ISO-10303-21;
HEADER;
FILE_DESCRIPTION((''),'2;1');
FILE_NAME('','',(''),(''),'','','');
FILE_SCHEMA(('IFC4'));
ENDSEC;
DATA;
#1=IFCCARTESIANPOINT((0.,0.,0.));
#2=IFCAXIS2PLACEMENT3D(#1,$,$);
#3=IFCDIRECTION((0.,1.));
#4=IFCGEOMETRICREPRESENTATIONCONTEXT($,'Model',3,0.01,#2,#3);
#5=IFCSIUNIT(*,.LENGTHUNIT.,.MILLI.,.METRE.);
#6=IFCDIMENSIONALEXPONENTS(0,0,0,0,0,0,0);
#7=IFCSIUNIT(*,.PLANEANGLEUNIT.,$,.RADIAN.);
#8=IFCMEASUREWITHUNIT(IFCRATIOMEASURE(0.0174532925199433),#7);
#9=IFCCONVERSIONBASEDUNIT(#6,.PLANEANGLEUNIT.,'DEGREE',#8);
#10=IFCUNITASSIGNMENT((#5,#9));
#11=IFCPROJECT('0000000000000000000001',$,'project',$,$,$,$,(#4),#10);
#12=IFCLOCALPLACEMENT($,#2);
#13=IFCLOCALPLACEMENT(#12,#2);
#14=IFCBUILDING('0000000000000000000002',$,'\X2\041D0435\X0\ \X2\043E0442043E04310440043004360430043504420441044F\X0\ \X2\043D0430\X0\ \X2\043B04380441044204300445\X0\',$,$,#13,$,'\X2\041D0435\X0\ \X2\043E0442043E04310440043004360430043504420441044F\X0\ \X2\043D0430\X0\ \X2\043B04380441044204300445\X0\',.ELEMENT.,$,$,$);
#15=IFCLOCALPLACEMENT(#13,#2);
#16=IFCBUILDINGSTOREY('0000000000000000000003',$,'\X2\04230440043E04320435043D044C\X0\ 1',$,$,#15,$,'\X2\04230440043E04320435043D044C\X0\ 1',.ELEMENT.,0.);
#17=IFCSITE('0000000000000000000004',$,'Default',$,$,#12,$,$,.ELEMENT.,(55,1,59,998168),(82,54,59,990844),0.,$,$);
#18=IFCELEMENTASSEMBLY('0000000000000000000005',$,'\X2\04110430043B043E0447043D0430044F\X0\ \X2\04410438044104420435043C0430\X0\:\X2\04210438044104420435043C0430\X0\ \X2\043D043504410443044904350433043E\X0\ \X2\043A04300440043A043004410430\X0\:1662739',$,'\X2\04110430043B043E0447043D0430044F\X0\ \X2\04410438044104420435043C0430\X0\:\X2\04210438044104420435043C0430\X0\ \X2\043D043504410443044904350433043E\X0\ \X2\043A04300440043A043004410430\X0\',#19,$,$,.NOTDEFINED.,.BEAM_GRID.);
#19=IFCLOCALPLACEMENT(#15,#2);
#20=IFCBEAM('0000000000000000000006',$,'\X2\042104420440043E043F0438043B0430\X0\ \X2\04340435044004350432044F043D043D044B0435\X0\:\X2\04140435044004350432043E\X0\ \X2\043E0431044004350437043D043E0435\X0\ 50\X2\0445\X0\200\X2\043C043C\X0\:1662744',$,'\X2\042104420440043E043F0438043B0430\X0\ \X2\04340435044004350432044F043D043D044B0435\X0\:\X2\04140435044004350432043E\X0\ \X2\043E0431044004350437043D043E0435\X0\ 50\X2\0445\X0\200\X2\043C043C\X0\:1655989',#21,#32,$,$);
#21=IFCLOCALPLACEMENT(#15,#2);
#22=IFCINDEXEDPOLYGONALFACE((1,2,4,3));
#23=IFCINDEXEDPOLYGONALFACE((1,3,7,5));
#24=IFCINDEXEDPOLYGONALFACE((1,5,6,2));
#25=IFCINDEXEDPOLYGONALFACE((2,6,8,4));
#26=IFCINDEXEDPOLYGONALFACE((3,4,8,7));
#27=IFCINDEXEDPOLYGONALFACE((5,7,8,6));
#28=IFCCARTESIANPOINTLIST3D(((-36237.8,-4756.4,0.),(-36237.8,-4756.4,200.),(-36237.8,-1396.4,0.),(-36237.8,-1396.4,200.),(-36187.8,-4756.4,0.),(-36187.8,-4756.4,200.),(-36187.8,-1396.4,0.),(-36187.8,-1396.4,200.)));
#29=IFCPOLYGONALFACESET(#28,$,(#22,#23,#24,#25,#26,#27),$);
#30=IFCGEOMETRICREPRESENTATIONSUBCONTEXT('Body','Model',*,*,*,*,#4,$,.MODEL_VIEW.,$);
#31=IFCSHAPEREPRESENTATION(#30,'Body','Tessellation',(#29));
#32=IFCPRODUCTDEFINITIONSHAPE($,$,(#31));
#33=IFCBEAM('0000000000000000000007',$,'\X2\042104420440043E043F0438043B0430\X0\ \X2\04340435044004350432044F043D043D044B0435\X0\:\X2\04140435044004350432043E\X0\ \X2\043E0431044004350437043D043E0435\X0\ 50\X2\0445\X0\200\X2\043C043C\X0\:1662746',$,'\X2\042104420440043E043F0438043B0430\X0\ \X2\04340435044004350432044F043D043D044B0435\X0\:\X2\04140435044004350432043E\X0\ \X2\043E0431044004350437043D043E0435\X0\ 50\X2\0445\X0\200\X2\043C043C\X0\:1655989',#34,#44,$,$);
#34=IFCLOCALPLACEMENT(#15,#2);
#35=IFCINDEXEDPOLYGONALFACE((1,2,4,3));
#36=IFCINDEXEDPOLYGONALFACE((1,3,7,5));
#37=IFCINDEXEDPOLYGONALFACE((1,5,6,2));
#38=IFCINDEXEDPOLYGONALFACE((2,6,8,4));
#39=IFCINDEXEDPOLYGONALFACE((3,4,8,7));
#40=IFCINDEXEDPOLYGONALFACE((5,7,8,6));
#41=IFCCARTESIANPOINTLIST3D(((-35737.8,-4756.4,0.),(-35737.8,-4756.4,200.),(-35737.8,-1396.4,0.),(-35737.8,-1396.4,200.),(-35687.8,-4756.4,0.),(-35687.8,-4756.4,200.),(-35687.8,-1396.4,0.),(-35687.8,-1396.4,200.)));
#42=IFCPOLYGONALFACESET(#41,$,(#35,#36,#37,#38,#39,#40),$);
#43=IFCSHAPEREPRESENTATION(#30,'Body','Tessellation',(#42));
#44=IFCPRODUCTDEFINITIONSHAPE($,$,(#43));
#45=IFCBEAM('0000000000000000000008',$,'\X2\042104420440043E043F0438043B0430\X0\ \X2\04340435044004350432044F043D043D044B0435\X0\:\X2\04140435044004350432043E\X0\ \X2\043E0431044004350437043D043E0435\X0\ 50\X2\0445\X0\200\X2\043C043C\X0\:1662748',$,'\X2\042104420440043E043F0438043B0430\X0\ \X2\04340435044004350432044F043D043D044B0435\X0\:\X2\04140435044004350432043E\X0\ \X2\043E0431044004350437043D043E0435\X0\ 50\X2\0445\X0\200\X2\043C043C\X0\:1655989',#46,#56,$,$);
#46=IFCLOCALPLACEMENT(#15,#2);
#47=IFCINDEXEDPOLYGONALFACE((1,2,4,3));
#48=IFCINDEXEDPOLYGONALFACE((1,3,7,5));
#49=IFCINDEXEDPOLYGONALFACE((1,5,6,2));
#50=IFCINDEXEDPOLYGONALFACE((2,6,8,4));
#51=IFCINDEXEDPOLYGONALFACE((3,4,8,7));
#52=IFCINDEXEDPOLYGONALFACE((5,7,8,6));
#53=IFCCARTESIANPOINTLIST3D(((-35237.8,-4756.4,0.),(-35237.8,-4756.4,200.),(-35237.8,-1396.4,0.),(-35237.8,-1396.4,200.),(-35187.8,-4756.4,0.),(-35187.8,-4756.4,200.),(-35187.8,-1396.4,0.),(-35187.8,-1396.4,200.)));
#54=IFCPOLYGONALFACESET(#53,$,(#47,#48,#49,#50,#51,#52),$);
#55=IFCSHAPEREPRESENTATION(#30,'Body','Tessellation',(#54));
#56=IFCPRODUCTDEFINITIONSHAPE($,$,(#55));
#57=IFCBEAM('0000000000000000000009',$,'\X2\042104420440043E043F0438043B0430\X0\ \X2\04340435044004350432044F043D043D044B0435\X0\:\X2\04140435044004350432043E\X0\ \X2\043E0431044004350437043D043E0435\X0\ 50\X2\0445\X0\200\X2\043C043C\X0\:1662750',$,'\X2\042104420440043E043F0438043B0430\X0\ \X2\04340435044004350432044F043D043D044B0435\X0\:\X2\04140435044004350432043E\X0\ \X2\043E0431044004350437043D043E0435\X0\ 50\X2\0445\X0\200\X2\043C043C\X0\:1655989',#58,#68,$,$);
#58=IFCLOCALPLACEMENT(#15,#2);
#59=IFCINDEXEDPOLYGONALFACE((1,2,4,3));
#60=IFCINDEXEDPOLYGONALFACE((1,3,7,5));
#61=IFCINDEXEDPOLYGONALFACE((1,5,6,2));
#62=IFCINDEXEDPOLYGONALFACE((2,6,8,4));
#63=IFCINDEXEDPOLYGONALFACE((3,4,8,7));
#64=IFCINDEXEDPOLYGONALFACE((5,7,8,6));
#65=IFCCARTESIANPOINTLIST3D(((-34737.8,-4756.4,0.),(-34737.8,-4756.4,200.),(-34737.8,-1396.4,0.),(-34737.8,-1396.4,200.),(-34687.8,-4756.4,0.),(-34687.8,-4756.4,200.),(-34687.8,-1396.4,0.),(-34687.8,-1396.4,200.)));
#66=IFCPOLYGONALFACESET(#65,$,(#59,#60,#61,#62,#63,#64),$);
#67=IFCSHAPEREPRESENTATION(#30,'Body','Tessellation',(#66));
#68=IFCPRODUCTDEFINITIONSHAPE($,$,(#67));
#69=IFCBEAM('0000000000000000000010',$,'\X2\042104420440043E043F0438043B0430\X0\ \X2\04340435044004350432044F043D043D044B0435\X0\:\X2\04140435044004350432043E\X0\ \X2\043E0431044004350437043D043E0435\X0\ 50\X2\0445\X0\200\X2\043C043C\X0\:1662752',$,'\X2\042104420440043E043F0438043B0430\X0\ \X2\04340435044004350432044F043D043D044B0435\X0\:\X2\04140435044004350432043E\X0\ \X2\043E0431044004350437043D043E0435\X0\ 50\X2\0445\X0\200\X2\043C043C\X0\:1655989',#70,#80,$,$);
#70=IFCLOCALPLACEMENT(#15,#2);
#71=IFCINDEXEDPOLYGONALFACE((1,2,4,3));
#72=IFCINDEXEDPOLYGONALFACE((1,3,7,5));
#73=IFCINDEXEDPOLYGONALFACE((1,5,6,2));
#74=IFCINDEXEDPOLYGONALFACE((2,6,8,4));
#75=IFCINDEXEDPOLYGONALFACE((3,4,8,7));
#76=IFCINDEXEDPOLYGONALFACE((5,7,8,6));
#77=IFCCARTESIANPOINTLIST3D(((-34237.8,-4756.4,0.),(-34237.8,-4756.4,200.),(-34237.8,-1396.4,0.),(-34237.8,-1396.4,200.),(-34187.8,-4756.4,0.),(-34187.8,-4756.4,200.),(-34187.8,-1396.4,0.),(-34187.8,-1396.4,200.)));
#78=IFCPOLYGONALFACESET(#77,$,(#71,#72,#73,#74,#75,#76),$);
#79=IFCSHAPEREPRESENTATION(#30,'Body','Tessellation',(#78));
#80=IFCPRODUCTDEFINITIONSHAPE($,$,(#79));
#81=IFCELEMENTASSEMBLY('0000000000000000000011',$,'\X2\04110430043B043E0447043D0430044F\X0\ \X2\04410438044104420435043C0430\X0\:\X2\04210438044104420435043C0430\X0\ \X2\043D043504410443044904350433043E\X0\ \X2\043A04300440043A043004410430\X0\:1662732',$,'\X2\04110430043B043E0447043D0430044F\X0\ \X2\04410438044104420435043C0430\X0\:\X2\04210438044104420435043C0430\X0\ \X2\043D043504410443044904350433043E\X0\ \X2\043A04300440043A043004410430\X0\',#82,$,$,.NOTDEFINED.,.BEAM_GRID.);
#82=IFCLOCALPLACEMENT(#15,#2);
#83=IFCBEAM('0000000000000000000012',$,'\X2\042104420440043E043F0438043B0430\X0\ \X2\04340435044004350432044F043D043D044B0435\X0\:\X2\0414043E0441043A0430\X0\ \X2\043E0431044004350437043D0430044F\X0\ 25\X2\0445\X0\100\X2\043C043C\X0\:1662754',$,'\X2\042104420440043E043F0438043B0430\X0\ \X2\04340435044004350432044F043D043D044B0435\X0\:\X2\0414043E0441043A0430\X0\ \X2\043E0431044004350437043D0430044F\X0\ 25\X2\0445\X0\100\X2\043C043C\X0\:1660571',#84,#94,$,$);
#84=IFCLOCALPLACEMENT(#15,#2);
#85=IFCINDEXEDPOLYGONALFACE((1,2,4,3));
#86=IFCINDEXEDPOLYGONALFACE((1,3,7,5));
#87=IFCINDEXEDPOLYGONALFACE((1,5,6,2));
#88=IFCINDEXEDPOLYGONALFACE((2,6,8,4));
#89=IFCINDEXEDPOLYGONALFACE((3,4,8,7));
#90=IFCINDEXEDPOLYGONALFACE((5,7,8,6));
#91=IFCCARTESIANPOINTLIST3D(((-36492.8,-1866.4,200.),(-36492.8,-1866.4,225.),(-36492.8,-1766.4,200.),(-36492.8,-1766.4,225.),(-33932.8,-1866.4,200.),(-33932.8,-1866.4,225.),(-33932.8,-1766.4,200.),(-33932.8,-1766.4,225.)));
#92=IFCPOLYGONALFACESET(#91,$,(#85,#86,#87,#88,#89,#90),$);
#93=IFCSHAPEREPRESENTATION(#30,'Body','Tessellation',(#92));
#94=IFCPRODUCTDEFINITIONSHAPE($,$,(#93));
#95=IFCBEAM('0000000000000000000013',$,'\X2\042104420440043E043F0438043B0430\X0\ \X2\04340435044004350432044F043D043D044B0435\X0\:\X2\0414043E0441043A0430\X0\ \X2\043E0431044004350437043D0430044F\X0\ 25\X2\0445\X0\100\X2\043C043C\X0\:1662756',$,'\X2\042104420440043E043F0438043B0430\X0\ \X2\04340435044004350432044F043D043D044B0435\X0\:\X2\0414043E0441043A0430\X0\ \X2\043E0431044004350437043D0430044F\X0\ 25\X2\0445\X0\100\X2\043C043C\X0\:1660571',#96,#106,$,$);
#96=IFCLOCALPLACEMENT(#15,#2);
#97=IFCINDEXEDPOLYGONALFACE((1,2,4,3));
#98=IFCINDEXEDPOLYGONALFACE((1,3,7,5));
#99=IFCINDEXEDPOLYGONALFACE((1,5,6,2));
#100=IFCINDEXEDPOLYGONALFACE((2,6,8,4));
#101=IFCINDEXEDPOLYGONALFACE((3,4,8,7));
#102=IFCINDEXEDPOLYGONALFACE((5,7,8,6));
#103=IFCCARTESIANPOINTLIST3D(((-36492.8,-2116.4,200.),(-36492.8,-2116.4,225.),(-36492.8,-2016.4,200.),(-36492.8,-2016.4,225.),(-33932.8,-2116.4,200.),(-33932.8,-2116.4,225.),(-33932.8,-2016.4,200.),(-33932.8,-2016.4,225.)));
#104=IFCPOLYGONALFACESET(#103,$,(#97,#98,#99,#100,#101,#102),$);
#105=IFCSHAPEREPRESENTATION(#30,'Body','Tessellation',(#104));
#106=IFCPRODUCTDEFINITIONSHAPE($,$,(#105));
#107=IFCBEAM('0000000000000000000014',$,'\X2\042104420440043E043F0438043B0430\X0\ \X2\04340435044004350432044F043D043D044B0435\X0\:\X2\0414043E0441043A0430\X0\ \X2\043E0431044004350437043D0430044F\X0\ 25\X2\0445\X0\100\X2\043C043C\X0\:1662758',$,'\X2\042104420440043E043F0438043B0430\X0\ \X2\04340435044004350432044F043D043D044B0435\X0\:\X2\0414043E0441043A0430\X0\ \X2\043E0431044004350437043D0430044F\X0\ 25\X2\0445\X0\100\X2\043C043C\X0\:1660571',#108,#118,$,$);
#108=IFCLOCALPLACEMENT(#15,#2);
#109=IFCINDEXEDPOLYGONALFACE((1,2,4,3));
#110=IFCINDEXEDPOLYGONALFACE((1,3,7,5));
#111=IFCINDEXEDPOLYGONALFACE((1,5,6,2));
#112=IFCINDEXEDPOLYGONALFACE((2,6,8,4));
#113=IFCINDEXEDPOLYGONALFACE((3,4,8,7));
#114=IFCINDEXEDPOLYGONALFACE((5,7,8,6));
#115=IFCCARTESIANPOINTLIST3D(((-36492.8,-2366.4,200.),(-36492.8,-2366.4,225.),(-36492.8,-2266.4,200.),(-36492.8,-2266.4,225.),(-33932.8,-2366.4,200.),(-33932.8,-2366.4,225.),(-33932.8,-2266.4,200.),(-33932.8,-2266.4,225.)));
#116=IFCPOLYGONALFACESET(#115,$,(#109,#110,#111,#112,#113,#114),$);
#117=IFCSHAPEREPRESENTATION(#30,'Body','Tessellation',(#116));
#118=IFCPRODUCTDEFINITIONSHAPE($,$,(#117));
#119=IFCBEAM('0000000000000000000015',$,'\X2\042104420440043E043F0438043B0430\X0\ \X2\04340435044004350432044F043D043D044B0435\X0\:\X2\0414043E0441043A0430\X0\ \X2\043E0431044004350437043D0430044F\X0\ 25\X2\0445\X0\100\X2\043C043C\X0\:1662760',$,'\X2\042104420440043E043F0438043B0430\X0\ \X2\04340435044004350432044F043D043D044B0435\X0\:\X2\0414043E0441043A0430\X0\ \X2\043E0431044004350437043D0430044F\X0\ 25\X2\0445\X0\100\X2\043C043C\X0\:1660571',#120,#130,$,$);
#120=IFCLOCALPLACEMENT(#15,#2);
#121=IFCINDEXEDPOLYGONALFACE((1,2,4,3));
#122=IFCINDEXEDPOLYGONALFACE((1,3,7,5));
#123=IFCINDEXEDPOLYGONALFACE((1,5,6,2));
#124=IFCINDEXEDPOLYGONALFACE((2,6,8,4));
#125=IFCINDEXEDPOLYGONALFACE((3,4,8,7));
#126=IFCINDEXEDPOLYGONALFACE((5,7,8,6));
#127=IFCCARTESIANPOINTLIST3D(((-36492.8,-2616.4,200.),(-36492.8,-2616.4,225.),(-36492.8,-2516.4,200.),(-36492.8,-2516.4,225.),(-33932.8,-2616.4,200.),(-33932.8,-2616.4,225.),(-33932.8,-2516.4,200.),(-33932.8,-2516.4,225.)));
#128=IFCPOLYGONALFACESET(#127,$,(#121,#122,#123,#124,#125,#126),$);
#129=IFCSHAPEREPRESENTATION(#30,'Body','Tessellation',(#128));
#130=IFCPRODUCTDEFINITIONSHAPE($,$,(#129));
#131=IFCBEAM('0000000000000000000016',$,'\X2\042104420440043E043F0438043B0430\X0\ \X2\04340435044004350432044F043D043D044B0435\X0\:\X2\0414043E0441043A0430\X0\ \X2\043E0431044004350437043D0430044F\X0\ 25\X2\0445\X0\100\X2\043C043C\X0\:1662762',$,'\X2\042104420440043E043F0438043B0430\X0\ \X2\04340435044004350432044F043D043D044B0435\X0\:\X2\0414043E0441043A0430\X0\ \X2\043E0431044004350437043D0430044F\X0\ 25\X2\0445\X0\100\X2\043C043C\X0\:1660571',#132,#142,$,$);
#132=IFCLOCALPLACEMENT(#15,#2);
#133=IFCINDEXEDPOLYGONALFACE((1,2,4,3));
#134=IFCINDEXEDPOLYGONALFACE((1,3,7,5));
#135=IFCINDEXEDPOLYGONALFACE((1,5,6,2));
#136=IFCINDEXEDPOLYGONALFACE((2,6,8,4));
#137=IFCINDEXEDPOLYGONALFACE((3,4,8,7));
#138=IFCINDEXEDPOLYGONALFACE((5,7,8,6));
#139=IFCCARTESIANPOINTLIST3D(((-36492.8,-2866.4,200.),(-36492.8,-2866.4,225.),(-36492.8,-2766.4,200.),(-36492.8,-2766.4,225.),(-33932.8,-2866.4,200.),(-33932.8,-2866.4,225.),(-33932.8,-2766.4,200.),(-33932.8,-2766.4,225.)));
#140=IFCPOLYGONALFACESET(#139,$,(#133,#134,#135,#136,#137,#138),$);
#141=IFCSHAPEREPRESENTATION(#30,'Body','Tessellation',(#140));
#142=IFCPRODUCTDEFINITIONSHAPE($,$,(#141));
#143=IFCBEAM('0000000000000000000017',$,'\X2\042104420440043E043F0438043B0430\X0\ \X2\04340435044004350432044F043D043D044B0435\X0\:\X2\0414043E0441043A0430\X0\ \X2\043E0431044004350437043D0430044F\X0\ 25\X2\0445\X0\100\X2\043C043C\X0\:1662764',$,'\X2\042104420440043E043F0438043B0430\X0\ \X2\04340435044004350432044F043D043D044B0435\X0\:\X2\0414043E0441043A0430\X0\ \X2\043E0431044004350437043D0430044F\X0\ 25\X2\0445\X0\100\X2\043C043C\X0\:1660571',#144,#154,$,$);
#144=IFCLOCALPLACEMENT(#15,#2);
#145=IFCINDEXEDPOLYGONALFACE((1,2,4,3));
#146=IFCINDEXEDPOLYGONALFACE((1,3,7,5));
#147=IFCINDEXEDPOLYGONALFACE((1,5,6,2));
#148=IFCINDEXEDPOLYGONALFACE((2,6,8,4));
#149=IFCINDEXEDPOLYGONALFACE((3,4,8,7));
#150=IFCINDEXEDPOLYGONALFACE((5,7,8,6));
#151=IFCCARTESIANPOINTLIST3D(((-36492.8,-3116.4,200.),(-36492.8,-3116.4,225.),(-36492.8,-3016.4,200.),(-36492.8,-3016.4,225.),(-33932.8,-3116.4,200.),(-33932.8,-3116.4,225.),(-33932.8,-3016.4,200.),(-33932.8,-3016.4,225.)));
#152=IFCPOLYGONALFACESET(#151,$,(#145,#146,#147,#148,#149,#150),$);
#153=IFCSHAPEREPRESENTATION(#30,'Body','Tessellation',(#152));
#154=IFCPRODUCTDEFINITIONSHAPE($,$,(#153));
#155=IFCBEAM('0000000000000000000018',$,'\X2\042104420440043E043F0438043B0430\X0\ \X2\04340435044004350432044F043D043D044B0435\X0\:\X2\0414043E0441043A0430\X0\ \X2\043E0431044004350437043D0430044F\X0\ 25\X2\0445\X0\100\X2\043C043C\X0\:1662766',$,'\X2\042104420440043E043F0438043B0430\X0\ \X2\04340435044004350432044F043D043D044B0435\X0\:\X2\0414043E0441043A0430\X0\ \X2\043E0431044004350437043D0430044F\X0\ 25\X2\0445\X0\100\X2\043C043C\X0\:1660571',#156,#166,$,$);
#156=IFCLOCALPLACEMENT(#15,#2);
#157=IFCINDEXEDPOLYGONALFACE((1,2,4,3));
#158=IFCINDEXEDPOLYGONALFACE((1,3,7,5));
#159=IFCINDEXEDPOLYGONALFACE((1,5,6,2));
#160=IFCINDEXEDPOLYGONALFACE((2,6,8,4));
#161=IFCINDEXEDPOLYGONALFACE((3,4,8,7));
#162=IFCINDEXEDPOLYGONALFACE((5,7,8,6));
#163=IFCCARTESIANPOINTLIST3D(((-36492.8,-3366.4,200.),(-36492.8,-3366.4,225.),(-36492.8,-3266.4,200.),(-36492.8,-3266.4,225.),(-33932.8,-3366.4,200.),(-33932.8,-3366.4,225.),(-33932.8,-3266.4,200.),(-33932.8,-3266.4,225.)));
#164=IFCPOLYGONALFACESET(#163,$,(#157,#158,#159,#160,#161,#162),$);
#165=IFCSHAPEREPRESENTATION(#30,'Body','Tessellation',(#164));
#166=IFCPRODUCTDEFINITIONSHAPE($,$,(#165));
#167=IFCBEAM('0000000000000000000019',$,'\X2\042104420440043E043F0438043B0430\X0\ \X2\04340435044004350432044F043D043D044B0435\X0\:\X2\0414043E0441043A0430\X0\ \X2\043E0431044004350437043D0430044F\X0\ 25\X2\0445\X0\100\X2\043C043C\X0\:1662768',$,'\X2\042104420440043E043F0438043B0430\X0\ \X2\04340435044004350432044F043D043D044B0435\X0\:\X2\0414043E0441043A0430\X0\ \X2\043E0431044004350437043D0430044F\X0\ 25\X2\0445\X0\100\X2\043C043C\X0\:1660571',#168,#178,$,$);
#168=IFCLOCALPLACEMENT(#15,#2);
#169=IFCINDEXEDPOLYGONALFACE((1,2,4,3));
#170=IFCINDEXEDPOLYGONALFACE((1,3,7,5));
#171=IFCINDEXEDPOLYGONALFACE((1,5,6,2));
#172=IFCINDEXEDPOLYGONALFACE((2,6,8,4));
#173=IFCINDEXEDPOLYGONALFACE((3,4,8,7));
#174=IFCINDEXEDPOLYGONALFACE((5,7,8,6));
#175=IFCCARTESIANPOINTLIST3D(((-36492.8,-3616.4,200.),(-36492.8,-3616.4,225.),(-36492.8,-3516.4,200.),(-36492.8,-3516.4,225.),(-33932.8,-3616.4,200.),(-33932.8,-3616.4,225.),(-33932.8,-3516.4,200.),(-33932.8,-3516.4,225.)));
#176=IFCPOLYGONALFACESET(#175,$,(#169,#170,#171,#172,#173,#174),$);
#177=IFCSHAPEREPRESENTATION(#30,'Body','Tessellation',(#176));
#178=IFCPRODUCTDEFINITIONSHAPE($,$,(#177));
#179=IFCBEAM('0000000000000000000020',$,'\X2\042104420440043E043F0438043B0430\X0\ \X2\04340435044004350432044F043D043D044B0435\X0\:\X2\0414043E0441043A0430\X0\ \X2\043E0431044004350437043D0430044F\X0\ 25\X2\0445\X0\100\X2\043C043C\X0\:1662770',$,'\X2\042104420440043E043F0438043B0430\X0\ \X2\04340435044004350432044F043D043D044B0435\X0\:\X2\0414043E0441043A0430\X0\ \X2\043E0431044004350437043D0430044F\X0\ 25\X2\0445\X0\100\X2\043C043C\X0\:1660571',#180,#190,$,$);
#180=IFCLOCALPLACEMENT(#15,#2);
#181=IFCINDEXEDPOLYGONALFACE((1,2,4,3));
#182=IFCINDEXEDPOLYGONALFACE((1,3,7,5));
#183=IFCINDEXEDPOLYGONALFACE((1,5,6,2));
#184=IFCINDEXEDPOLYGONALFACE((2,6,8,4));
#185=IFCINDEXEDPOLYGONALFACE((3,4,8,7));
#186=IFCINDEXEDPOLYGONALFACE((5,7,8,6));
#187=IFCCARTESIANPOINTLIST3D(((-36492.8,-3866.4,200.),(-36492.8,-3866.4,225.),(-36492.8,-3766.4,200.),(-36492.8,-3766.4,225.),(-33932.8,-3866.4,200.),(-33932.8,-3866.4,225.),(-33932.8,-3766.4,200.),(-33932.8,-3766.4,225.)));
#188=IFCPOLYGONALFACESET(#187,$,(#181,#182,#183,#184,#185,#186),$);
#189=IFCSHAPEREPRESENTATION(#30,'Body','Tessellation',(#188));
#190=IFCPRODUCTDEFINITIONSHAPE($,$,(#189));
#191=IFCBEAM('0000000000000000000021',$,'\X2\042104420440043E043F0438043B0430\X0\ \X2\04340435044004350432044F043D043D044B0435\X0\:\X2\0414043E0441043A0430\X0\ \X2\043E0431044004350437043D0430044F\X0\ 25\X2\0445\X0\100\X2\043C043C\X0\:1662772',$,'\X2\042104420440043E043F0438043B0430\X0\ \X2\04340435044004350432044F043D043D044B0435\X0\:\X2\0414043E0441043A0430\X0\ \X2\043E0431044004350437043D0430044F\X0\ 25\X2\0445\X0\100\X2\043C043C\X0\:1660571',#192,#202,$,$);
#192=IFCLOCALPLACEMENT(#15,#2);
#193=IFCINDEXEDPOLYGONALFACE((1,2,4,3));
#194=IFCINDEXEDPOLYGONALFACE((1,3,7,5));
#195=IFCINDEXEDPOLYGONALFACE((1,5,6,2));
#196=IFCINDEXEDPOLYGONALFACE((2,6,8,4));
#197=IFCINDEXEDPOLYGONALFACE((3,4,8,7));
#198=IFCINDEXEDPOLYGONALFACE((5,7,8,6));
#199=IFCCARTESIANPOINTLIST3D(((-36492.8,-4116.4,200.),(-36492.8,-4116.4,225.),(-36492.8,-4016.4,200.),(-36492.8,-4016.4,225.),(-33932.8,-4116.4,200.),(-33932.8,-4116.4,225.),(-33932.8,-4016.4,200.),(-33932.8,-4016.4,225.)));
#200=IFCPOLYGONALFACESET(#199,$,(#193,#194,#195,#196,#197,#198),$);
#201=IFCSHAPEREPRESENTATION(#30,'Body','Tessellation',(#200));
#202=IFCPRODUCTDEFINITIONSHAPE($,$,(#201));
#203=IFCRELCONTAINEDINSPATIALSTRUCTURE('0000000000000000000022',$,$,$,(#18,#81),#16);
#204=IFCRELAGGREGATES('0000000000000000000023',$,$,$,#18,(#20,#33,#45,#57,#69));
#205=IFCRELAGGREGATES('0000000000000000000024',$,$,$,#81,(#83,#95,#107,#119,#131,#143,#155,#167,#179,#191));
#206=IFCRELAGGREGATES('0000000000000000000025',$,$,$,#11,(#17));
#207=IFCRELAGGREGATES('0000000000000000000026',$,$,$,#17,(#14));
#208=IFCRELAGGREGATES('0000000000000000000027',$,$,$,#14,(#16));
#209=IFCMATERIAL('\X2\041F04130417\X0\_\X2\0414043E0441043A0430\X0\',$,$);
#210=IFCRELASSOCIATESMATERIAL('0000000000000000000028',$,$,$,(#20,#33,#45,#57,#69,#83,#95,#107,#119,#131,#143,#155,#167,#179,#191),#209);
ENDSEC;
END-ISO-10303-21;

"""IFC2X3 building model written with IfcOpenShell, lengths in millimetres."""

from ifc_helpers import new_model, entity, si_unit, converted_unit, direction, frame, frame_2d, origin, origin_2d_with_axis, place, context, subcontext, project, spatial, rectangle, extrude, material, element, aggregate, save


model = new_model("IFC2X3")

# Units and contexts
model_context = context("Model", 3, precision=0.01, world=origin(), true_north=direction((0.0, 1.0)))
body_context = subcontext(model_context, "Body", "Model", "MODEL_VIEW")
ifc_project = project(units=[si_unit("LENGTHUNIT", "METRE", prefix="MILLI"), converted_unit("PLANEANGLEUNIT", "DEGREE", entity("IfcRatioMeasure", 0.0174532925199433), si_unit("PLANEANGLEUNIT", "RADIAN"), dimensions=[0, 0, 0, 0, 0, 0, 0])], contexts=[model_context])

# Site, building, storey
site_placement = place(None, origin())
site = spatial("IfcSite", under=ifc_project, at=site_placement, Name="Default", CompositionType="ELEMENT", RefLatitude=(55, 1, 59, 998168), RefLongitude=(82, 54, 59, 990844), RefElevation=0.0)
building_placement = place(site_placement, origin())
building = spatial("IfcBuilding", under=site, at=building_placement, Name="Не отображается на листах", LongName="Не отображается на листах", CompositionType="ELEMENT")
storey_placement = place(building_placement, frame((0.0, 0.0, 0.0)))
storey = spatial("IfcBuildingStorey", under=building, at=storey_placement, Name="Уровень 1", LongName="Уровень 1", CompositionType="ELEMENT", Elevation=0.0)

# Element assemblies, beams
assembly_1_placement = place(storey_placement, origin())
assembly_1 = element("IfcElementAssembly", 1, at=assembly_1_placement, inside=storey, Name="Балочная система:Система несущего каркаса:1662739", ObjectType="Балочная система:Система несущего каркаса", AssemblyPlace="NOTDEFINED", PredefinedType="BEAM_GRID")
ifc_material_1 = material(Name="ПГЗ_Доска")
beam_1_placement = place(assembly_1_placement, frame((-36212.8, -4756.4, 0.0), z_axis=(0.0, 0.0, 1.0), x_axis=(0.0, 1.0, 0.0)))
beam_1 = element("IfcBeam", 2, at=beam_1_placement, material=ifc_material_1, Name="Стропила деревянные:Дерево обрезное 50х200мм:1662744", ObjectType="Стропила деревянные:Дерево обрезное 50х200мм:1655989", context=body_context, shape_type="SweptSolid", body=[
    extrude(rectangle(XDim=200.0, YDim=50.0, at=frame_2d((0.0, 0.0), x_axis=(1.0, 0.0))), frame((0.0, 0.0, 100.0), z_axis=(1.0, 0.0, 0.0), x_axis=(0.0, 0.0, -1.0)), (0.0, 0.0, 1.0), 3360.0),
])
beam_2_placement = place(assembly_1_placement, frame((-35712.8, -4756.4, 0.0), z_axis=(0.0, 0.0, 1.0), x_axis=(0.0, 1.0, 0.0)))
beam_2 = element("IfcBeam", 3, at=beam_2_placement, material=ifc_material_1, Name="Стропила деревянные:Дерево обрезное 50х200мм:1662746", ObjectType="Стропила деревянные:Дерево обрезное 50х200мм:1655989", context=body_context, shape_type="SweptSolid", body=[
    extrude(rectangle(XDim=200.0, YDim=50.0, at=frame_2d((0.0, 0.0), x_axis=(1.0, 0.0))), frame((0.0, 0.0, 100.0), z_axis=(1.0, 0.0, 0.0), x_axis=(0.0, 0.0, -1.0)), (0.0, 0.0, 1.0), 3360.0),
])
beam_3_placement = place(assembly_1_placement, frame((-35212.8, -4756.4, 0.0), z_axis=(0.0, 0.0, 1.0), x_axis=(0.0, 1.0, 0.0)))
beam_3 = element("IfcBeam", 4, at=beam_3_placement, material=ifc_material_1, Name="Стропила деревянные:Дерево обрезное 50х200мм:1662748", ObjectType="Стропила деревянные:Дерево обрезное 50х200мм:1655989", context=body_context, shape_type="SweptSolid", body=[
    extrude(rectangle(XDim=200.0, YDim=50.0, at=frame_2d((0.0, 0.0), x_axis=(1.0, 0.0))), frame((0.0, 0.0, 100.0), z_axis=(1.0, 0.0, 0.0), x_axis=(0.0, 0.0, -1.0)), (0.0, 0.0, 1.0), 3360.0),
])
beam_4_placement = place(assembly_1_placement, frame((-34712.8, -4756.4, 0.0), z_axis=(0.0, 0.0, 1.0), x_axis=(0.0, 1.0, 0.0)))
beam_4 = element("IfcBeam", 5, at=beam_4_placement, material=ifc_material_1, Name="Стропила деревянные:Дерево обрезное 50х200мм:1662750", ObjectType="Стропила деревянные:Дерево обрезное 50х200мм:1655989", context=body_context, shape_type="SweptSolid", body=[
    extrude(rectangle(XDim=200.0, YDim=50.0, at=frame_2d((0.0, 0.0), x_axis=(1.0, 0.0))), frame((0.0, 0.0, 100.0), z_axis=(1.0, 0.0, 0.0), x_axis=(0.0, 0.0, -1.0)), (0.0, 0.0, 1.0), 3360.0),
])
beam_5_placement = place(assembly_1_placement, frame((-34212.8, -4756.4, 0.0), z_axis=(0.0, 0.0, 1.0), x_axis=(0.0, 1.0, 0.0)))
beam_5 = element("IfcBeam", 6, at=beam_5_placement, material=ifc_material_1, Name="Стропила деревянные:Дерево обрезное 50х200мм:1662752", ObjectType="Стропила деревянные:Дерево обрезное 50х200мм:1655989", context=body_context, shape_type="SweptSolid", body=[
    extrude(rectangle(XDim=200.0, YDim=50.0, at=frame_2d((0.0, 0.0), x_axis=(1.0, 0.0))), frame((0.0, 0.0, 100.0), z_axis=(1.0, 0.0, 0.0), x_axis=(0.0, 0.0, -1.0)), (0.0, 0.0, 1.0), 3360.0),
])
aggregate(assembly_1, [beam_1, beam_2, beam_3, beam_4, beam_5])
assembly_2_placement = place(storey_placement, origin())
assembly_2 = element("IfcElementAssembly", 7, at=assembly_2_placement, inside=storey, Name="Балочная система:Система несущего каркаса:1662732", ObjectType="Балочная система:Система несущего каркаса", AssemblyPlace="NOTDEFINED", PredefinedType="BEAM_GRID")
beam_6_placement = place(assembly_2_placement, frame((-36492.8, -1816.4, 0.0)))
beam_6 = element("IfcBeam", 8, at=beam_6_placement, material=ifc_material_1, Name="Стропила деревянные:Доска обрезная 25х100мм:1662754", ObjectType="Стропила деревянные:Доска обрезная 25х100мм:1660571", context=body_context, shape_type="SweptSolid", body=[
    extrude(rectangle(XDim=25.0, YDim=100.0, at=origin_2d_with_axis()), frame((0.0, 0.0, 212.5), z_axis=(1.0, 0.0, 0.0), x_axis=(0.0, 0.0, -1.0)), (0.0, 0.0, 1.0), 2560.0),
])
beam_7_placement = place(assembly_2_placement, frame((-36492.8, -2066.4, 0.0)))
beam_7 = element("IfcBeam", 9, at=beam_7_placement, material=ifc_material_1, Name="Стропила деревянные:Доска обрезная 25х100мм:1662756", ObjectType="Стропила деревянные:Доска обрезная 25х100мм:1660571", context=body_context, shape_type="SweptSolid", body=[
    extrude(rectangle(XDim=25.0, YDim=100.0, at=origin_2d_with_axis()), frame((0.0, 0.0, 212.5), z_axis=(1.0, 0.0, 0.0), x_axis=(0.0, 0.0, -1.0)), (0.0, 0.0, 1.0), 2560.0),
])
beam_8_placement = place(assembly_2_placement, frame((-36492.8, -2316.4, 0.0)))
beam_8 = element("IfcBeam", 10, at=beam_8_placement, material=ifc_material_1, Name="Стропила деревянные:Доска обрезная 25х100мм:1662758", ObjectType="Стропила деревянные:Доска обрезная 25х100мм:1660571", context=body_context, shape_type="SweptSolid", body=[
    extrude(rectangle(XDim=25.0, YDim=100.0, at=origin_2d_with_axis()), frame((0.0, 0.0, 212.5), z_axis=(1.0, 0.0, 0.0), x_axis=(0.0, 0.0, -1.0)), (0.0, 0.0, 1.0), 2560.0),
])
beam_9_placement = place(assembly_2_placement, frame((-36492.8, -2566.4, 0.0)))
beam_9 = element("IfcBeam", 11, at=beam_9_placement, material=ifc_material_1, Name="Стропила деревянные:Доска обрезная 25х100мм:1662760", ObjectType="Стропила деревянные:Доска обрезная 25х100мм:1660571", context=body_context, shape_type="SweptSolid", body=[
    extrude(rectangle(XDim=25.0, YDim=100.0, at=origin_2d_with_axis()), frame((0.0, 0.0, 212.5), z_axis=(1.0, 0.0, 0.0), x_axis=(0.0, 0.0, -1.0)), (0.0, 0.0, 1.0), 2560.0),
])
beam_10_placement = place(assembly_2_placement, frame((-36492.8, -2816.4, 0.0)))
beam_10 = element("IfcBeam", 12, at=beam_10_placement, material=ifc_material_1, Name="Стропила деревянные:Доска обрезная 25х100мм:1662762", ObjectType="Стропила деревянные:Доска обрезная 25х100мм:1660571", context=body_context, shape_type="SweptSolid", body=[
    extrude(rectangle(XDim=25.0, YDim=100.0, at=origin_2d_with_axis()), frame((0.0, 0.0, 212.5), z_axis=(1.0, 0.0, 0.0), x_axis=(0.0, 0.0, -1.0)), (0.0, 0.0, 1.0), 2560.0),
])
beam_11_placement = place(assembly_2_placement, frame((-36492.8, -3066.4, 0.0)))
beam_11 = element("IfcBeam", 13, at=beam_11_placement, material=ifc_material_1, Name="Стропила деревянные:Доска обрезная 25х100мм:1662764", ObjectType="Стропила деревянные:Доска обрезная 25х100мм:1660571", context=body_context, shape_type="SweptSolid", body=[
    extrude(rectangle(XDim=25.0, YDim=100.0, at=origin_2d_with_axis()), frame((0.0, 0.0, 212.5), z_axis=(1.0, 0.0, 0.0), x_axis=(0.0, 0.0, -1.0)), (0.0, 0.0, 1.0), 2560.0),
])
beam_12_placement = place(assembly_2_placement, frame((-36492.8, -3316.4, 0.0)))
beam_12 = element("IfcBeam", 14, at=beam_12_placement, material=ifc_material_1, Name="Стропила деревянные:Доска обрезная 25х100мм:1662766", ObjectType="Стропила деревянные:Доска обрезная 25х100мм:1660571", context=body_context, shape_type="SweptSolid", body=[
    extrude(rectangle(XDim=25.0, YDim=100.0, at=origin_2d_with_axis()), frame((0.0, 0.0, 212.5), z_axis=(1.0, 0.0, 0.0), x_axis=(0.0, 0.0, -1.0)), (0.0, 0.0, 1.0), 2560.0),
])
beam_13_placement = place(assembly_2_placement, frame((-36492.8, -3566.4, 0.0)))
beam_13 = element("IfcBeam", 15, at=beam_13_placement, material=ifc_material_1, Name="Стропила деревянные:Доска обрезная 25х100мм:1662768", ObjectType="Стропила деревянные:Доска обрезная 25х100мм:1660571", context=body_context, shape_type="SweptSolid", body=[
    extrude(rectangle(XDim=25.0, YDim=100.0, at=origin_2d_with_axis()), frame((0.0, 0.0, 212.5), z_axis=(1.0, 0.0, 0.0), x_axis=(0.0, 0.0, -1.0)), (0.0, 0.0, 1.0), 2560.0),
])
beam_14_placement = place(assembly_2_placement, frame((-36492.8, -3816.4, 0.0)))
beam_14 = element("IfcBeam", 16, at=beam_14_placement, material=ifc_material_1, Name="Стропила деревянные:Доска обрезная 25х100мм:1662770", ObjectType="Стропила деревянные:Доска обрезная 25х100мм:1660571", context=body_context, shape_type="SweptSolid", body=[
    extrude(rectangle(XDim=25.0, YDim=100.0, at=origin_2d_with_axis()), frame((0.0, 0.0, 212.5), z_axis=(1.0, 0.0, 0.0), x_axis=(0.0, 0.0, -1.0)), (0.0, 0.0, 1.0), 2560.0),
])
beam_15_placement = place(assembly_2_placement, frame((-36492.8, -4066.4, 0.0)))
beam_15 = element("IfcBeam", 17, at=beam_15_placement, material=ifc_material_1, Name="Стропила деревянные:Доска обрезная 25х100мм:1662772", ObjectType="Стропила деревянные:Доска обрезная 25х100мм:1660571", context=body_context, shape_type="SweptSolid", body=[
    extrude(rectangle(XDim=25.0, YDim=100.0, at=origin_2d_with_axis()), frame((0.0, 0.0, 212.5), z_axis=(1.0, 0.0, 0.0), x_axis=(0.0, 0.0, -1.0)), (0.0, 0.0, 1.0), 2560.0),
])
aggregate(assembly_2, [beam_6, beam_7, beam_8, beam_9, beam_10, beam_11, beam_12, beam_13, beam_14, beam_15])

save(model, "model.ifc")
